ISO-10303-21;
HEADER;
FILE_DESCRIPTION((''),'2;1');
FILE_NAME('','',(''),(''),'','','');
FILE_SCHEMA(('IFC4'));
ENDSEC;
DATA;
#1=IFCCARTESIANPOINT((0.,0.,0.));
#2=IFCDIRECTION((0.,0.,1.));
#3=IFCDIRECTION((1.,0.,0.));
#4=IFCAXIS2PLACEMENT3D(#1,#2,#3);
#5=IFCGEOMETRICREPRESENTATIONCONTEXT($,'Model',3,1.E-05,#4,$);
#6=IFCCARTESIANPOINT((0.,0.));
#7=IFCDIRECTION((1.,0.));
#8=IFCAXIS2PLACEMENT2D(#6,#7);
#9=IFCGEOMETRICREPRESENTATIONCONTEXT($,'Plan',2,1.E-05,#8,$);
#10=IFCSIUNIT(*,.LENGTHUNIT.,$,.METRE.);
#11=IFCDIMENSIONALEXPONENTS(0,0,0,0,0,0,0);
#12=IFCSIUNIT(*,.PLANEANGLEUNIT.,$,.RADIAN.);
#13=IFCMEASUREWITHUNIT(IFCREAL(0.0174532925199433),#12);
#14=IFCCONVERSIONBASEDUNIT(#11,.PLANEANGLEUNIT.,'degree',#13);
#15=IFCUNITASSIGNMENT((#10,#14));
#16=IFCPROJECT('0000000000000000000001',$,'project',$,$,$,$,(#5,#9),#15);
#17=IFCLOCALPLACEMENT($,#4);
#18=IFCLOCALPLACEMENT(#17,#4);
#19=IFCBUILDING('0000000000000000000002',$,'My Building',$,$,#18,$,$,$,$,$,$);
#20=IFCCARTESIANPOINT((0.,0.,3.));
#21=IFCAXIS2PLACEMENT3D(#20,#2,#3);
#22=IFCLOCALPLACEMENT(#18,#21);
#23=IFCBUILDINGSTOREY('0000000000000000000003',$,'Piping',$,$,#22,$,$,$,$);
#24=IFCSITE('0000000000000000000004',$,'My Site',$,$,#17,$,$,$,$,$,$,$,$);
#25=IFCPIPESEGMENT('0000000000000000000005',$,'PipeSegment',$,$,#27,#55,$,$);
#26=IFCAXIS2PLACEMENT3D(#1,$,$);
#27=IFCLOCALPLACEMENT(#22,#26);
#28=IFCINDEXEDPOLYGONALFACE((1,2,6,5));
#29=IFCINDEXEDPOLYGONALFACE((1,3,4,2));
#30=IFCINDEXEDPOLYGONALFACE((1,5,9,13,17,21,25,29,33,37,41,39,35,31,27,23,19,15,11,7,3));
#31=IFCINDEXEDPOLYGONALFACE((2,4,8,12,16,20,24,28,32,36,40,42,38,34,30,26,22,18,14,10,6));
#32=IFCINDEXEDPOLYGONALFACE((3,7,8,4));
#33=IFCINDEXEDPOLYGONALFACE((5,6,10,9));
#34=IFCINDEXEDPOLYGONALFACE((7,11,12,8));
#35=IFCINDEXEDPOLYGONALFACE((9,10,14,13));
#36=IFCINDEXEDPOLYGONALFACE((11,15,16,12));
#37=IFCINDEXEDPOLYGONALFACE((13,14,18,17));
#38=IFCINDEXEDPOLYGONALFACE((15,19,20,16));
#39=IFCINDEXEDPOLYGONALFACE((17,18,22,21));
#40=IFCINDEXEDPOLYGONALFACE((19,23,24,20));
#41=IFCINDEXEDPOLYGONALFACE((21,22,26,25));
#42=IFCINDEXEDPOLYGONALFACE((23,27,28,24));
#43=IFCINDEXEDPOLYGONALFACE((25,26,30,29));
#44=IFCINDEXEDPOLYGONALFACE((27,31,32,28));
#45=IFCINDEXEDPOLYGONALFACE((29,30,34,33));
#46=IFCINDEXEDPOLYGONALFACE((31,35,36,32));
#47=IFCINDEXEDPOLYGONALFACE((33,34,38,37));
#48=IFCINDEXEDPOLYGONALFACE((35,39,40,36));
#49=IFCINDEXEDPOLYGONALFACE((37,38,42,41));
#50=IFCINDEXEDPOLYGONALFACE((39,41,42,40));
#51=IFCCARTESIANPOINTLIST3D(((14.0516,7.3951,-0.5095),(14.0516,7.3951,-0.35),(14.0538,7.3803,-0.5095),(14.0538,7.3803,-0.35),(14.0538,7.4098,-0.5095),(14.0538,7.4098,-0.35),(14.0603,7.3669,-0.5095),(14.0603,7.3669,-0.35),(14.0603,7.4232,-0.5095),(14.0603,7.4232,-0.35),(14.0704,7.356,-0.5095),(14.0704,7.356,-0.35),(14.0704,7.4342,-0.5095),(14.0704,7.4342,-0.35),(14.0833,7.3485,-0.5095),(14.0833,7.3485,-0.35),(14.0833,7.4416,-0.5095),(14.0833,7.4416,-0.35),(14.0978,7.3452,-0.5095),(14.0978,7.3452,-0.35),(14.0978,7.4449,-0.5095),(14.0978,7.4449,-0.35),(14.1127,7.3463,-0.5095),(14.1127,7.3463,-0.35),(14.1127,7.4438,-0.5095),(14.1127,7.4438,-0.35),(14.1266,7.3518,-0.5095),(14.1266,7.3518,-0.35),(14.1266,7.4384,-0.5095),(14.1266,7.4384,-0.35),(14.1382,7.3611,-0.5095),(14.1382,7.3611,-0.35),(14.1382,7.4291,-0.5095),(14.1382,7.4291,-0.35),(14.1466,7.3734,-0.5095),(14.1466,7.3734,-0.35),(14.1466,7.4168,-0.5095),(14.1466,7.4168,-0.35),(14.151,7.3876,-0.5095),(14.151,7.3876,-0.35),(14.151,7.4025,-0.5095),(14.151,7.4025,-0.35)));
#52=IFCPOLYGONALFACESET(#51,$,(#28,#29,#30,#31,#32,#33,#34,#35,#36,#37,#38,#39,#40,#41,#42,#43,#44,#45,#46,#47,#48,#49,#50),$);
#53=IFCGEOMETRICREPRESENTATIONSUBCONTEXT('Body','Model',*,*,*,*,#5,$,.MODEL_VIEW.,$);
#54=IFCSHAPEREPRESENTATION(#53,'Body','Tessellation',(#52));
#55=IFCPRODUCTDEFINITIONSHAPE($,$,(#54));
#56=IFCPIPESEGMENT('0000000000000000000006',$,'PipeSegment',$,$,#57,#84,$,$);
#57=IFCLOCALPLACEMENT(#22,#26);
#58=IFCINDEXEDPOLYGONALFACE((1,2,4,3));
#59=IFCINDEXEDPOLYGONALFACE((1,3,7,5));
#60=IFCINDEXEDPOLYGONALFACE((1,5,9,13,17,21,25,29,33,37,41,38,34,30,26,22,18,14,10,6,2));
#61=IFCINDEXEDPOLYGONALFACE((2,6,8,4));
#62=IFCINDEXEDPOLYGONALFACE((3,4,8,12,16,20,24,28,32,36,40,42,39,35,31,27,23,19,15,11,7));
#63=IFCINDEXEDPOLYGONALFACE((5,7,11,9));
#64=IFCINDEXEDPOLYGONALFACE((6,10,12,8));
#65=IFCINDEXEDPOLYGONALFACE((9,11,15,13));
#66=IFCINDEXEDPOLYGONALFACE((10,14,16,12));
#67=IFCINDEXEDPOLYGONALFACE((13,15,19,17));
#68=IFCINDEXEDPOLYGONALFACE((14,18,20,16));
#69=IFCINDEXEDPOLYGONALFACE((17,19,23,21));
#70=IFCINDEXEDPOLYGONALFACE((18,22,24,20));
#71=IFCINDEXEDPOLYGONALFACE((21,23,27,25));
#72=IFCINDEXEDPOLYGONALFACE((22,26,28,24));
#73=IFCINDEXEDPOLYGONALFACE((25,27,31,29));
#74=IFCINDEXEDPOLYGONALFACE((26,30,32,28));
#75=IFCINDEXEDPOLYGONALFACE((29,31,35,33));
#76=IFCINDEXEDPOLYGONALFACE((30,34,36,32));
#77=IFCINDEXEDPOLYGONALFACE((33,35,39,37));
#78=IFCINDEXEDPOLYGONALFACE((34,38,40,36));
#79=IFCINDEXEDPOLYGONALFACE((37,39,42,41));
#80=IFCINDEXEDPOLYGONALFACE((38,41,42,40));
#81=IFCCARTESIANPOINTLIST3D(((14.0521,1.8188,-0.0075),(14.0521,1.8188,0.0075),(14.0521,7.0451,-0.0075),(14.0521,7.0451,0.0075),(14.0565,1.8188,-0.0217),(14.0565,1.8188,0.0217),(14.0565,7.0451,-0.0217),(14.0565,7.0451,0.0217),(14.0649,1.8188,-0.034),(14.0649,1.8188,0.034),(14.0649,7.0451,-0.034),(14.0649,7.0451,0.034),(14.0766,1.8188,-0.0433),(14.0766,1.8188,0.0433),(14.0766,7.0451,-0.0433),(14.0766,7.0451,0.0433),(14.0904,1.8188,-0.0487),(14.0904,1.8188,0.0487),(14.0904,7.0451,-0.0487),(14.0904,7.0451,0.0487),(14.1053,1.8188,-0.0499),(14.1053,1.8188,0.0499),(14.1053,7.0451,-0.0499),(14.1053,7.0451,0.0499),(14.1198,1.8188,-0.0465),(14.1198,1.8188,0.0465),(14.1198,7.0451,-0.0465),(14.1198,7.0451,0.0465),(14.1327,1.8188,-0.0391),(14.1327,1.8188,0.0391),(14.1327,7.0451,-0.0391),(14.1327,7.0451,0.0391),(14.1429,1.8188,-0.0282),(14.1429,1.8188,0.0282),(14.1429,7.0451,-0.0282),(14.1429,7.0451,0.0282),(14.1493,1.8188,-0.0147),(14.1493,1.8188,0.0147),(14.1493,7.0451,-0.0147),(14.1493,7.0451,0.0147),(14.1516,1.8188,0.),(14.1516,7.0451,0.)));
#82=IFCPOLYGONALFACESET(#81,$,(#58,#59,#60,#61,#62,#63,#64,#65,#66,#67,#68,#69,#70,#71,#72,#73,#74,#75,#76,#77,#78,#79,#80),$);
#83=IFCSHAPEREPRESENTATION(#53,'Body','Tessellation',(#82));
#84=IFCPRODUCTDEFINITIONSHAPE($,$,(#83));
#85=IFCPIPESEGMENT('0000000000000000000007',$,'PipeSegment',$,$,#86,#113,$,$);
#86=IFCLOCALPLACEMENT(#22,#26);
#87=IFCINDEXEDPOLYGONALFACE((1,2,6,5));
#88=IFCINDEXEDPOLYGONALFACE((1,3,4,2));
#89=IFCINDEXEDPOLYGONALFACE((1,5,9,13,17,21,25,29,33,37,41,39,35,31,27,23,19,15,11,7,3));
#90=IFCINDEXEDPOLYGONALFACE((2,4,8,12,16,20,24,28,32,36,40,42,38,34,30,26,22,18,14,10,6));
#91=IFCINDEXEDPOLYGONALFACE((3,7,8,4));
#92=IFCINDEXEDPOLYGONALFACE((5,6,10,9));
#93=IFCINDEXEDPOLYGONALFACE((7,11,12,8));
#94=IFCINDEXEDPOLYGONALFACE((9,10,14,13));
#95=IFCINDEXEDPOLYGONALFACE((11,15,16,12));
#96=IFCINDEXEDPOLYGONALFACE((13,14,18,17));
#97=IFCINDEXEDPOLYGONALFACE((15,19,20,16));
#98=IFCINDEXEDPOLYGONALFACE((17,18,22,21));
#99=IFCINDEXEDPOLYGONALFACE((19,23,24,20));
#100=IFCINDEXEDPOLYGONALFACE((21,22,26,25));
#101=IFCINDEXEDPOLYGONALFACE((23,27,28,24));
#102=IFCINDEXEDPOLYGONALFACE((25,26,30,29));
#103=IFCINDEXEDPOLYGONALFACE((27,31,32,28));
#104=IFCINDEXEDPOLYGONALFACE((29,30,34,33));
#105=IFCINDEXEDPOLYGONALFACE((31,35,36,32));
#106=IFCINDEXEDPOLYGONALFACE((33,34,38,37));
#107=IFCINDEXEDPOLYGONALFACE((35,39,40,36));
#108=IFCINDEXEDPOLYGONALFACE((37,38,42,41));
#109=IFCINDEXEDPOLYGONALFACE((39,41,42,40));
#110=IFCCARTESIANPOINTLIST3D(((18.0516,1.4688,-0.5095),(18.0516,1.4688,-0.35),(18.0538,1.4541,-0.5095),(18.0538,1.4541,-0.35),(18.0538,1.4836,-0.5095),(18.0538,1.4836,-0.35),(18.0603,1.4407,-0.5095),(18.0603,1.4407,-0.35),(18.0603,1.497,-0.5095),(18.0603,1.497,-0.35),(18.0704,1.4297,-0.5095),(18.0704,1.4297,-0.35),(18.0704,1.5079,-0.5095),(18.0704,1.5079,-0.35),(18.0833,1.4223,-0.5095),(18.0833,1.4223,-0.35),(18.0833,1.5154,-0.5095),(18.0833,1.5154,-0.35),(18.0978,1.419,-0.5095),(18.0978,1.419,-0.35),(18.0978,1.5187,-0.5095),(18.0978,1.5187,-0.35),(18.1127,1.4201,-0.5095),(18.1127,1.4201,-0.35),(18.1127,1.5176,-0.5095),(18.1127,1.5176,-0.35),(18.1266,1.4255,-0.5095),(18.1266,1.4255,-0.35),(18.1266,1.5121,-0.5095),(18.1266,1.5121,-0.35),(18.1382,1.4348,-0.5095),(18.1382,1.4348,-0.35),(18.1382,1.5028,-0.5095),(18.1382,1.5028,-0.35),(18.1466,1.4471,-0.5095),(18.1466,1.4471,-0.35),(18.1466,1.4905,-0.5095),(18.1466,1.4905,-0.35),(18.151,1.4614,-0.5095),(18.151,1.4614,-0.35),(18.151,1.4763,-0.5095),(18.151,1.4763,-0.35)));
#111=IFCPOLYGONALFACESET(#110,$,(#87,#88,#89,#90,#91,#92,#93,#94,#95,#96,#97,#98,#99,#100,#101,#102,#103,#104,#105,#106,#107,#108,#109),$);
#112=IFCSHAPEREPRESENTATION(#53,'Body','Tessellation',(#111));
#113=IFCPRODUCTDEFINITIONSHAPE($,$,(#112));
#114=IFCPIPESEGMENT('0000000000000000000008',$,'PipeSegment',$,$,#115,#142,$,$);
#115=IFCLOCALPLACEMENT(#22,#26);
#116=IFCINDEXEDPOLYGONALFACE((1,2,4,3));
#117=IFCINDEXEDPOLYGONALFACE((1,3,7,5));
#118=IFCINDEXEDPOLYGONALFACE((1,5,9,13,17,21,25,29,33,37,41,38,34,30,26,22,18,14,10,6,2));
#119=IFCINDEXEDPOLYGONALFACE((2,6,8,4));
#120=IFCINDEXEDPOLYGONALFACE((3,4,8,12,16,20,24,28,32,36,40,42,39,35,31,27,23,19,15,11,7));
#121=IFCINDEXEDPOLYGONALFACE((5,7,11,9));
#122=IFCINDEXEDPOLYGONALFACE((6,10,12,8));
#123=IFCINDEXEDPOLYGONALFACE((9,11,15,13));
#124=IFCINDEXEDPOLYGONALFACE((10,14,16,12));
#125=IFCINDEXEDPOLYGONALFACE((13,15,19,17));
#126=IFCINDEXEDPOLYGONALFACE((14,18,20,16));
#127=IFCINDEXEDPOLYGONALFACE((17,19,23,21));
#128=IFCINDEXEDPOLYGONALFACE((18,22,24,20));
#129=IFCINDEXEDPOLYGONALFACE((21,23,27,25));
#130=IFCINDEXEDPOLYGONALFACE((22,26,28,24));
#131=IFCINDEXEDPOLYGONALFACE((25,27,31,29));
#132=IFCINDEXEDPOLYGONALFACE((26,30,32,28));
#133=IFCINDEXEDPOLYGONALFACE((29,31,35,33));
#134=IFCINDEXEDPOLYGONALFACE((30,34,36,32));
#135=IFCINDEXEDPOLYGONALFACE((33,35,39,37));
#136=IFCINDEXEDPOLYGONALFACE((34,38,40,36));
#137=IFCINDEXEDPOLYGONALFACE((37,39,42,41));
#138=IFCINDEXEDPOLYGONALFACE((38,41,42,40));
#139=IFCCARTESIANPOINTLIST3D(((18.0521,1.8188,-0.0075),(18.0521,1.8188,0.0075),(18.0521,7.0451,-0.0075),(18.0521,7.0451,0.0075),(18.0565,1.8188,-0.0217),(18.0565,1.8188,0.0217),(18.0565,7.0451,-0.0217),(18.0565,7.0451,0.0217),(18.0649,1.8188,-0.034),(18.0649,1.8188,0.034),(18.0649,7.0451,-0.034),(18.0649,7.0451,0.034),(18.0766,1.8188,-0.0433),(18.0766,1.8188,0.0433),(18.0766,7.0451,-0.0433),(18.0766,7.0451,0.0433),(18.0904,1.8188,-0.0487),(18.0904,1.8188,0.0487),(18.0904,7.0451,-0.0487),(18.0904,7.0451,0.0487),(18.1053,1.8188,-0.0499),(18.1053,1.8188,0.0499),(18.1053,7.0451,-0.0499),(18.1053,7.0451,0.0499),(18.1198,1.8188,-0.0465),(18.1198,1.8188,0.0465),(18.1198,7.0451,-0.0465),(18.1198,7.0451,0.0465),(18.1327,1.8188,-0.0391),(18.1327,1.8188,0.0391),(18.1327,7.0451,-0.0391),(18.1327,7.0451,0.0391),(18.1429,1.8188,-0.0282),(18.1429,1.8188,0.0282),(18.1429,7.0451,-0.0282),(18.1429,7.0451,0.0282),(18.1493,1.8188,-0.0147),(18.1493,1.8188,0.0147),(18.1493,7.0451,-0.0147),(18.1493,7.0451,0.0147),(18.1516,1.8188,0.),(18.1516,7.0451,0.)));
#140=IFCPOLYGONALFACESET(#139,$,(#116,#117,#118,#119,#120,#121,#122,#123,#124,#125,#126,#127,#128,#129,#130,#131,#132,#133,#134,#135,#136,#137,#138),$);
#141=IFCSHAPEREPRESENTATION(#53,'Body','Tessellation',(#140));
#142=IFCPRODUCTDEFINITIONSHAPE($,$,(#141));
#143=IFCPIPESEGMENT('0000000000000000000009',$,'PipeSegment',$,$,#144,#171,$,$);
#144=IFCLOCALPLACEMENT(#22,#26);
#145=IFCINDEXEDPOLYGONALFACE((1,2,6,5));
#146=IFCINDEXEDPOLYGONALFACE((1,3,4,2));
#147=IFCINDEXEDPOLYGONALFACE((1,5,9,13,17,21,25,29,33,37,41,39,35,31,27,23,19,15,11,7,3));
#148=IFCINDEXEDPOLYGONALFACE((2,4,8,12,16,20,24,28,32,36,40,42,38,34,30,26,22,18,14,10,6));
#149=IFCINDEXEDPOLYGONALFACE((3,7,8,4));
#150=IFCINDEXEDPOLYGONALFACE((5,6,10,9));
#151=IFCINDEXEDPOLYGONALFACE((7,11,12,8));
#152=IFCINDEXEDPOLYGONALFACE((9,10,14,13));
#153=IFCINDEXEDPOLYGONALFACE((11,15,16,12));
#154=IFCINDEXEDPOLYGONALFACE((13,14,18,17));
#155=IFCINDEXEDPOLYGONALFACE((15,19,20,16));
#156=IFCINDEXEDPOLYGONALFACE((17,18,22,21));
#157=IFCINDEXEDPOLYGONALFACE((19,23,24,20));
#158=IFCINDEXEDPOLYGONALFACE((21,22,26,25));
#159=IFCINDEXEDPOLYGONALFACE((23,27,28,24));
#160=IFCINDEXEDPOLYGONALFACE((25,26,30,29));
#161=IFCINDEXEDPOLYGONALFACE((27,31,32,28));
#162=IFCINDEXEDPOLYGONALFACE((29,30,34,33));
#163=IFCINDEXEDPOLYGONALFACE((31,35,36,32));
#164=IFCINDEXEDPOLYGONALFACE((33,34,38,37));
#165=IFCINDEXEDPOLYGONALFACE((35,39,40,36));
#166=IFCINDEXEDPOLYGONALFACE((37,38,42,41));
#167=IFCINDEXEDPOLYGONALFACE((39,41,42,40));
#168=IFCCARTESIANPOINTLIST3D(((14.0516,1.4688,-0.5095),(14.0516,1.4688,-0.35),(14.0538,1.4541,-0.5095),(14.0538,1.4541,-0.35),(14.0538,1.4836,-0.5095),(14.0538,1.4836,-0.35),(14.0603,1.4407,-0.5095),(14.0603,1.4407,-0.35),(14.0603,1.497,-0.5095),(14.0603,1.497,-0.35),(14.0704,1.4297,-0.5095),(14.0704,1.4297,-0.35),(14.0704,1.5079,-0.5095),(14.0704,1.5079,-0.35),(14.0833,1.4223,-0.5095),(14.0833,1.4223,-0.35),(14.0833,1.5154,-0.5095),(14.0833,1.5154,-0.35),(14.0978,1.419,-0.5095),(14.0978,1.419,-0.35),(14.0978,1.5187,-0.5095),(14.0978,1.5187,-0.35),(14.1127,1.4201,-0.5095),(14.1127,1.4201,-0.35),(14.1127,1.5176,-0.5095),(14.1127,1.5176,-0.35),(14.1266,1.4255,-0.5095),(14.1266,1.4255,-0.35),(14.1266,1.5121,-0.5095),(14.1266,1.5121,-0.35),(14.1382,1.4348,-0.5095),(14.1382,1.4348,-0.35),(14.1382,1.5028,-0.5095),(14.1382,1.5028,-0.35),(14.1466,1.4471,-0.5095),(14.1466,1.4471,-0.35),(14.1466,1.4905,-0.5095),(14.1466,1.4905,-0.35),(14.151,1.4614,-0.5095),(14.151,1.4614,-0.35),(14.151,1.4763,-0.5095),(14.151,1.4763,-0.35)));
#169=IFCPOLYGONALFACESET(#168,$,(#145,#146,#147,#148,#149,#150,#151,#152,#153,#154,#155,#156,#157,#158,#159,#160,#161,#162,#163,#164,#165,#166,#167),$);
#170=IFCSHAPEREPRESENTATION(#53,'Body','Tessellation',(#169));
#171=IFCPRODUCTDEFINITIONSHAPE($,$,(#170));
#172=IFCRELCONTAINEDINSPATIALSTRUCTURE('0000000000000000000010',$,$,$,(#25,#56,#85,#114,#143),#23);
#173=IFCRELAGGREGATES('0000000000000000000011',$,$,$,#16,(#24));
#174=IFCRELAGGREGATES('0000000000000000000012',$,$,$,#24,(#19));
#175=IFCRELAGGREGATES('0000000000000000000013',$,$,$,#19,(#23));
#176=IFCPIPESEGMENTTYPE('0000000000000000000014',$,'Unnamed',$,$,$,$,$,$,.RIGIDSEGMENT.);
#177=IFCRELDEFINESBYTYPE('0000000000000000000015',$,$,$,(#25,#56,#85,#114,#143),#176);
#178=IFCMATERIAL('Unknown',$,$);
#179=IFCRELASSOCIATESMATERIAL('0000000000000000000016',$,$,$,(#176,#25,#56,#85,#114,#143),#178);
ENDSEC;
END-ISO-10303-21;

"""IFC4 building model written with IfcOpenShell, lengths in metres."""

from ifc_helpers import new_model, entity, si_unit, converted_unit, frame, origin_with_axes, origin_2d_with_axis, place, context, subcontext, project, spatial, circle, extrude, material, material_profile, profile_set, profile_usage, type_object, element, save


model = new_model("IFC4")

# Units and contexts
model_context = context("Model", 3, precision=1e-05, world=origin_with_axes())
plan_context = context("Plan", 2, precision=1e-05, world=origin_2d_with_axis())
body_context = subcontext(model_context, "Body", "Model", "MODEL_VIEW")
ifc_project = project(units=[si_unit("LENGTHUNIT", "METRE"), converted_unit("PLANEANGLEUNIT", "degree", entity("IfcReal", 0.0174532925199433), si_unit("PLANEANGLEUNIT", "RADIAN"), dimensions=[0, 0, 0, 0, 0, 0, 0])], contexts=[model_context, plan_context])

# Site, building, storey
site_placement = place(None, origin_with_axes())
site = spatial("IfcSite", under=ifc_project, at=site_placement, Name="My Site")
building_placement = place(site_placement, origin_with_axes())
building = spatial("IfcBuilding", under=site, at=building_placement, Name="My Building")
storey_placement = place(building_placement, frame((0.0, 0.0, 3.0), z_axis=(0.0, 0.0, 1.0), x_axis=(1.0, 0.0, 0.0)))
storey = spatial("IfcBuildingStorey", under=building, at=storey_placement, Name="Piping")

# Pipe segments
ifc_material = material(Name="Unknown")
ifc_material_profile = material_profile(ifc_material, circle(Radius=0.05))
ifc_profile_set = profile_set([ifc_material_profile])
pipe_segment_type = type_object("IfcPipeSegmentType", Name="Unnamed", PredefinedType="RIGIDSEGMENT", material=ifc_profile_set)
ifc_profile_usage_1 = profile_usage(ifc_profile_set, cardinal=5)
pipe_segment_1_placement = place(storey_placement, frame((14.1016, 7.3951, -0.35), z_axis=(0.0, 0.0, -1.0), x_axis=(-1.0, 0.0, 0.0)))
element("IfcPipeSegment", 1, at=pipe_segment_1_placement, inside=storey, type_object=pipe_segment_type, material=ifc_profile_usage_1, Name="PipeSegment", context=body_context, shape_type="SweptSolid", body=[
    extrude(circle(Radius=0.05), origin_with_axes(), (0.0, 0.0, 1.0), 0.1595),
])
ifc_profile_usage_2 = profile_usage(ifc_profile_set, cardinal=5)
pipe_segment_2_placement = place(storey_placement, frame((14.1016, 1.8188, 0.0), z_axis=(0.0, 1.0, 0.0), x_axis=(1.0, 0.0, 0.0)))
element("IfcPipeSegment", 2, at=pipe_segment_2_placement, inside=storey, type_object=pipe_segment_type, material=ifc_profile_usage_2, Name="PipeSegment", context=body_context, shape_type="SweptSolid", body=[
    extrude(circle(Radius=0.05), origin_with_axes(), (0.0, 0.0, 1.0), 5.2262),
])
ifc_profile_usage_3 = profile_usage(ifc_profile_set, cardinal=5)
pipe_segment_3_placement = place(storey_placement, frame((18.1016, 1.4688, -0.35), z_axis=(0.0, 0.0, -1.0), x_axis=(-1.0, 0.0, 0.0)))
element("IfcPipeSegment", 3, at=pipe_segment_3_placement, inside=storey, type_object=pipe_segment_type, material=ifc_profile_usage_3, Name="PipeSegment", context=body_context, shape_type="SweptSolid", body=[
    extrude(circle(Radius=0.05), origin_with_axes(), (0.0, 0.0, 1.0), 0.1595),
])
ifc_profile_usage_4 = profile_usage(ifc_profile_set, cardinal=5)
pipe_segment_4_placement = place(storey_placement, frame((18.1016, 1.8188, 0.0), z_axis=(0.0, 1.0, 0.0), x_axis=(1.0, 0.0, 0.0)))
element("IfcPipeSegment", 4, at=pipe_segment_4_placement, inside=storey, type_object=pipe_segment_type, material=ifc_profile_usage_4, Name="PipeSegment", context=body_context, shape_type="SweptSolid", body=[
    extrude(circle(Radius=0.05), origin_with_axes(), (0.0, 0.0, 1.0), 5.2262),
])
ifc_profile_usage_5 = profile_usage(ifc_profile_set, cardinal=5)
pipe_segment_5_placement = place(storey_placement, frame((14.1016, 1.4688, -0.35), z_axis=(0.0, 0.0, -1.0), x_axis=(-1.0, 0.0, 0.0)))
element("IfcPipeSegment", 5, at=pipe_segment_5_placement, inside=storey, type_object=pipe_segment_type, material=ifc_profile_usage_5, Name="PipeSegment", context=body_context, shape_type="SweptSolid", body=[
    extrude(circle(Radius=0.05), origin_with_axes(), (0.0, 0.0, 1.0), 0.1595),
])

save(model, "model.ifc")
